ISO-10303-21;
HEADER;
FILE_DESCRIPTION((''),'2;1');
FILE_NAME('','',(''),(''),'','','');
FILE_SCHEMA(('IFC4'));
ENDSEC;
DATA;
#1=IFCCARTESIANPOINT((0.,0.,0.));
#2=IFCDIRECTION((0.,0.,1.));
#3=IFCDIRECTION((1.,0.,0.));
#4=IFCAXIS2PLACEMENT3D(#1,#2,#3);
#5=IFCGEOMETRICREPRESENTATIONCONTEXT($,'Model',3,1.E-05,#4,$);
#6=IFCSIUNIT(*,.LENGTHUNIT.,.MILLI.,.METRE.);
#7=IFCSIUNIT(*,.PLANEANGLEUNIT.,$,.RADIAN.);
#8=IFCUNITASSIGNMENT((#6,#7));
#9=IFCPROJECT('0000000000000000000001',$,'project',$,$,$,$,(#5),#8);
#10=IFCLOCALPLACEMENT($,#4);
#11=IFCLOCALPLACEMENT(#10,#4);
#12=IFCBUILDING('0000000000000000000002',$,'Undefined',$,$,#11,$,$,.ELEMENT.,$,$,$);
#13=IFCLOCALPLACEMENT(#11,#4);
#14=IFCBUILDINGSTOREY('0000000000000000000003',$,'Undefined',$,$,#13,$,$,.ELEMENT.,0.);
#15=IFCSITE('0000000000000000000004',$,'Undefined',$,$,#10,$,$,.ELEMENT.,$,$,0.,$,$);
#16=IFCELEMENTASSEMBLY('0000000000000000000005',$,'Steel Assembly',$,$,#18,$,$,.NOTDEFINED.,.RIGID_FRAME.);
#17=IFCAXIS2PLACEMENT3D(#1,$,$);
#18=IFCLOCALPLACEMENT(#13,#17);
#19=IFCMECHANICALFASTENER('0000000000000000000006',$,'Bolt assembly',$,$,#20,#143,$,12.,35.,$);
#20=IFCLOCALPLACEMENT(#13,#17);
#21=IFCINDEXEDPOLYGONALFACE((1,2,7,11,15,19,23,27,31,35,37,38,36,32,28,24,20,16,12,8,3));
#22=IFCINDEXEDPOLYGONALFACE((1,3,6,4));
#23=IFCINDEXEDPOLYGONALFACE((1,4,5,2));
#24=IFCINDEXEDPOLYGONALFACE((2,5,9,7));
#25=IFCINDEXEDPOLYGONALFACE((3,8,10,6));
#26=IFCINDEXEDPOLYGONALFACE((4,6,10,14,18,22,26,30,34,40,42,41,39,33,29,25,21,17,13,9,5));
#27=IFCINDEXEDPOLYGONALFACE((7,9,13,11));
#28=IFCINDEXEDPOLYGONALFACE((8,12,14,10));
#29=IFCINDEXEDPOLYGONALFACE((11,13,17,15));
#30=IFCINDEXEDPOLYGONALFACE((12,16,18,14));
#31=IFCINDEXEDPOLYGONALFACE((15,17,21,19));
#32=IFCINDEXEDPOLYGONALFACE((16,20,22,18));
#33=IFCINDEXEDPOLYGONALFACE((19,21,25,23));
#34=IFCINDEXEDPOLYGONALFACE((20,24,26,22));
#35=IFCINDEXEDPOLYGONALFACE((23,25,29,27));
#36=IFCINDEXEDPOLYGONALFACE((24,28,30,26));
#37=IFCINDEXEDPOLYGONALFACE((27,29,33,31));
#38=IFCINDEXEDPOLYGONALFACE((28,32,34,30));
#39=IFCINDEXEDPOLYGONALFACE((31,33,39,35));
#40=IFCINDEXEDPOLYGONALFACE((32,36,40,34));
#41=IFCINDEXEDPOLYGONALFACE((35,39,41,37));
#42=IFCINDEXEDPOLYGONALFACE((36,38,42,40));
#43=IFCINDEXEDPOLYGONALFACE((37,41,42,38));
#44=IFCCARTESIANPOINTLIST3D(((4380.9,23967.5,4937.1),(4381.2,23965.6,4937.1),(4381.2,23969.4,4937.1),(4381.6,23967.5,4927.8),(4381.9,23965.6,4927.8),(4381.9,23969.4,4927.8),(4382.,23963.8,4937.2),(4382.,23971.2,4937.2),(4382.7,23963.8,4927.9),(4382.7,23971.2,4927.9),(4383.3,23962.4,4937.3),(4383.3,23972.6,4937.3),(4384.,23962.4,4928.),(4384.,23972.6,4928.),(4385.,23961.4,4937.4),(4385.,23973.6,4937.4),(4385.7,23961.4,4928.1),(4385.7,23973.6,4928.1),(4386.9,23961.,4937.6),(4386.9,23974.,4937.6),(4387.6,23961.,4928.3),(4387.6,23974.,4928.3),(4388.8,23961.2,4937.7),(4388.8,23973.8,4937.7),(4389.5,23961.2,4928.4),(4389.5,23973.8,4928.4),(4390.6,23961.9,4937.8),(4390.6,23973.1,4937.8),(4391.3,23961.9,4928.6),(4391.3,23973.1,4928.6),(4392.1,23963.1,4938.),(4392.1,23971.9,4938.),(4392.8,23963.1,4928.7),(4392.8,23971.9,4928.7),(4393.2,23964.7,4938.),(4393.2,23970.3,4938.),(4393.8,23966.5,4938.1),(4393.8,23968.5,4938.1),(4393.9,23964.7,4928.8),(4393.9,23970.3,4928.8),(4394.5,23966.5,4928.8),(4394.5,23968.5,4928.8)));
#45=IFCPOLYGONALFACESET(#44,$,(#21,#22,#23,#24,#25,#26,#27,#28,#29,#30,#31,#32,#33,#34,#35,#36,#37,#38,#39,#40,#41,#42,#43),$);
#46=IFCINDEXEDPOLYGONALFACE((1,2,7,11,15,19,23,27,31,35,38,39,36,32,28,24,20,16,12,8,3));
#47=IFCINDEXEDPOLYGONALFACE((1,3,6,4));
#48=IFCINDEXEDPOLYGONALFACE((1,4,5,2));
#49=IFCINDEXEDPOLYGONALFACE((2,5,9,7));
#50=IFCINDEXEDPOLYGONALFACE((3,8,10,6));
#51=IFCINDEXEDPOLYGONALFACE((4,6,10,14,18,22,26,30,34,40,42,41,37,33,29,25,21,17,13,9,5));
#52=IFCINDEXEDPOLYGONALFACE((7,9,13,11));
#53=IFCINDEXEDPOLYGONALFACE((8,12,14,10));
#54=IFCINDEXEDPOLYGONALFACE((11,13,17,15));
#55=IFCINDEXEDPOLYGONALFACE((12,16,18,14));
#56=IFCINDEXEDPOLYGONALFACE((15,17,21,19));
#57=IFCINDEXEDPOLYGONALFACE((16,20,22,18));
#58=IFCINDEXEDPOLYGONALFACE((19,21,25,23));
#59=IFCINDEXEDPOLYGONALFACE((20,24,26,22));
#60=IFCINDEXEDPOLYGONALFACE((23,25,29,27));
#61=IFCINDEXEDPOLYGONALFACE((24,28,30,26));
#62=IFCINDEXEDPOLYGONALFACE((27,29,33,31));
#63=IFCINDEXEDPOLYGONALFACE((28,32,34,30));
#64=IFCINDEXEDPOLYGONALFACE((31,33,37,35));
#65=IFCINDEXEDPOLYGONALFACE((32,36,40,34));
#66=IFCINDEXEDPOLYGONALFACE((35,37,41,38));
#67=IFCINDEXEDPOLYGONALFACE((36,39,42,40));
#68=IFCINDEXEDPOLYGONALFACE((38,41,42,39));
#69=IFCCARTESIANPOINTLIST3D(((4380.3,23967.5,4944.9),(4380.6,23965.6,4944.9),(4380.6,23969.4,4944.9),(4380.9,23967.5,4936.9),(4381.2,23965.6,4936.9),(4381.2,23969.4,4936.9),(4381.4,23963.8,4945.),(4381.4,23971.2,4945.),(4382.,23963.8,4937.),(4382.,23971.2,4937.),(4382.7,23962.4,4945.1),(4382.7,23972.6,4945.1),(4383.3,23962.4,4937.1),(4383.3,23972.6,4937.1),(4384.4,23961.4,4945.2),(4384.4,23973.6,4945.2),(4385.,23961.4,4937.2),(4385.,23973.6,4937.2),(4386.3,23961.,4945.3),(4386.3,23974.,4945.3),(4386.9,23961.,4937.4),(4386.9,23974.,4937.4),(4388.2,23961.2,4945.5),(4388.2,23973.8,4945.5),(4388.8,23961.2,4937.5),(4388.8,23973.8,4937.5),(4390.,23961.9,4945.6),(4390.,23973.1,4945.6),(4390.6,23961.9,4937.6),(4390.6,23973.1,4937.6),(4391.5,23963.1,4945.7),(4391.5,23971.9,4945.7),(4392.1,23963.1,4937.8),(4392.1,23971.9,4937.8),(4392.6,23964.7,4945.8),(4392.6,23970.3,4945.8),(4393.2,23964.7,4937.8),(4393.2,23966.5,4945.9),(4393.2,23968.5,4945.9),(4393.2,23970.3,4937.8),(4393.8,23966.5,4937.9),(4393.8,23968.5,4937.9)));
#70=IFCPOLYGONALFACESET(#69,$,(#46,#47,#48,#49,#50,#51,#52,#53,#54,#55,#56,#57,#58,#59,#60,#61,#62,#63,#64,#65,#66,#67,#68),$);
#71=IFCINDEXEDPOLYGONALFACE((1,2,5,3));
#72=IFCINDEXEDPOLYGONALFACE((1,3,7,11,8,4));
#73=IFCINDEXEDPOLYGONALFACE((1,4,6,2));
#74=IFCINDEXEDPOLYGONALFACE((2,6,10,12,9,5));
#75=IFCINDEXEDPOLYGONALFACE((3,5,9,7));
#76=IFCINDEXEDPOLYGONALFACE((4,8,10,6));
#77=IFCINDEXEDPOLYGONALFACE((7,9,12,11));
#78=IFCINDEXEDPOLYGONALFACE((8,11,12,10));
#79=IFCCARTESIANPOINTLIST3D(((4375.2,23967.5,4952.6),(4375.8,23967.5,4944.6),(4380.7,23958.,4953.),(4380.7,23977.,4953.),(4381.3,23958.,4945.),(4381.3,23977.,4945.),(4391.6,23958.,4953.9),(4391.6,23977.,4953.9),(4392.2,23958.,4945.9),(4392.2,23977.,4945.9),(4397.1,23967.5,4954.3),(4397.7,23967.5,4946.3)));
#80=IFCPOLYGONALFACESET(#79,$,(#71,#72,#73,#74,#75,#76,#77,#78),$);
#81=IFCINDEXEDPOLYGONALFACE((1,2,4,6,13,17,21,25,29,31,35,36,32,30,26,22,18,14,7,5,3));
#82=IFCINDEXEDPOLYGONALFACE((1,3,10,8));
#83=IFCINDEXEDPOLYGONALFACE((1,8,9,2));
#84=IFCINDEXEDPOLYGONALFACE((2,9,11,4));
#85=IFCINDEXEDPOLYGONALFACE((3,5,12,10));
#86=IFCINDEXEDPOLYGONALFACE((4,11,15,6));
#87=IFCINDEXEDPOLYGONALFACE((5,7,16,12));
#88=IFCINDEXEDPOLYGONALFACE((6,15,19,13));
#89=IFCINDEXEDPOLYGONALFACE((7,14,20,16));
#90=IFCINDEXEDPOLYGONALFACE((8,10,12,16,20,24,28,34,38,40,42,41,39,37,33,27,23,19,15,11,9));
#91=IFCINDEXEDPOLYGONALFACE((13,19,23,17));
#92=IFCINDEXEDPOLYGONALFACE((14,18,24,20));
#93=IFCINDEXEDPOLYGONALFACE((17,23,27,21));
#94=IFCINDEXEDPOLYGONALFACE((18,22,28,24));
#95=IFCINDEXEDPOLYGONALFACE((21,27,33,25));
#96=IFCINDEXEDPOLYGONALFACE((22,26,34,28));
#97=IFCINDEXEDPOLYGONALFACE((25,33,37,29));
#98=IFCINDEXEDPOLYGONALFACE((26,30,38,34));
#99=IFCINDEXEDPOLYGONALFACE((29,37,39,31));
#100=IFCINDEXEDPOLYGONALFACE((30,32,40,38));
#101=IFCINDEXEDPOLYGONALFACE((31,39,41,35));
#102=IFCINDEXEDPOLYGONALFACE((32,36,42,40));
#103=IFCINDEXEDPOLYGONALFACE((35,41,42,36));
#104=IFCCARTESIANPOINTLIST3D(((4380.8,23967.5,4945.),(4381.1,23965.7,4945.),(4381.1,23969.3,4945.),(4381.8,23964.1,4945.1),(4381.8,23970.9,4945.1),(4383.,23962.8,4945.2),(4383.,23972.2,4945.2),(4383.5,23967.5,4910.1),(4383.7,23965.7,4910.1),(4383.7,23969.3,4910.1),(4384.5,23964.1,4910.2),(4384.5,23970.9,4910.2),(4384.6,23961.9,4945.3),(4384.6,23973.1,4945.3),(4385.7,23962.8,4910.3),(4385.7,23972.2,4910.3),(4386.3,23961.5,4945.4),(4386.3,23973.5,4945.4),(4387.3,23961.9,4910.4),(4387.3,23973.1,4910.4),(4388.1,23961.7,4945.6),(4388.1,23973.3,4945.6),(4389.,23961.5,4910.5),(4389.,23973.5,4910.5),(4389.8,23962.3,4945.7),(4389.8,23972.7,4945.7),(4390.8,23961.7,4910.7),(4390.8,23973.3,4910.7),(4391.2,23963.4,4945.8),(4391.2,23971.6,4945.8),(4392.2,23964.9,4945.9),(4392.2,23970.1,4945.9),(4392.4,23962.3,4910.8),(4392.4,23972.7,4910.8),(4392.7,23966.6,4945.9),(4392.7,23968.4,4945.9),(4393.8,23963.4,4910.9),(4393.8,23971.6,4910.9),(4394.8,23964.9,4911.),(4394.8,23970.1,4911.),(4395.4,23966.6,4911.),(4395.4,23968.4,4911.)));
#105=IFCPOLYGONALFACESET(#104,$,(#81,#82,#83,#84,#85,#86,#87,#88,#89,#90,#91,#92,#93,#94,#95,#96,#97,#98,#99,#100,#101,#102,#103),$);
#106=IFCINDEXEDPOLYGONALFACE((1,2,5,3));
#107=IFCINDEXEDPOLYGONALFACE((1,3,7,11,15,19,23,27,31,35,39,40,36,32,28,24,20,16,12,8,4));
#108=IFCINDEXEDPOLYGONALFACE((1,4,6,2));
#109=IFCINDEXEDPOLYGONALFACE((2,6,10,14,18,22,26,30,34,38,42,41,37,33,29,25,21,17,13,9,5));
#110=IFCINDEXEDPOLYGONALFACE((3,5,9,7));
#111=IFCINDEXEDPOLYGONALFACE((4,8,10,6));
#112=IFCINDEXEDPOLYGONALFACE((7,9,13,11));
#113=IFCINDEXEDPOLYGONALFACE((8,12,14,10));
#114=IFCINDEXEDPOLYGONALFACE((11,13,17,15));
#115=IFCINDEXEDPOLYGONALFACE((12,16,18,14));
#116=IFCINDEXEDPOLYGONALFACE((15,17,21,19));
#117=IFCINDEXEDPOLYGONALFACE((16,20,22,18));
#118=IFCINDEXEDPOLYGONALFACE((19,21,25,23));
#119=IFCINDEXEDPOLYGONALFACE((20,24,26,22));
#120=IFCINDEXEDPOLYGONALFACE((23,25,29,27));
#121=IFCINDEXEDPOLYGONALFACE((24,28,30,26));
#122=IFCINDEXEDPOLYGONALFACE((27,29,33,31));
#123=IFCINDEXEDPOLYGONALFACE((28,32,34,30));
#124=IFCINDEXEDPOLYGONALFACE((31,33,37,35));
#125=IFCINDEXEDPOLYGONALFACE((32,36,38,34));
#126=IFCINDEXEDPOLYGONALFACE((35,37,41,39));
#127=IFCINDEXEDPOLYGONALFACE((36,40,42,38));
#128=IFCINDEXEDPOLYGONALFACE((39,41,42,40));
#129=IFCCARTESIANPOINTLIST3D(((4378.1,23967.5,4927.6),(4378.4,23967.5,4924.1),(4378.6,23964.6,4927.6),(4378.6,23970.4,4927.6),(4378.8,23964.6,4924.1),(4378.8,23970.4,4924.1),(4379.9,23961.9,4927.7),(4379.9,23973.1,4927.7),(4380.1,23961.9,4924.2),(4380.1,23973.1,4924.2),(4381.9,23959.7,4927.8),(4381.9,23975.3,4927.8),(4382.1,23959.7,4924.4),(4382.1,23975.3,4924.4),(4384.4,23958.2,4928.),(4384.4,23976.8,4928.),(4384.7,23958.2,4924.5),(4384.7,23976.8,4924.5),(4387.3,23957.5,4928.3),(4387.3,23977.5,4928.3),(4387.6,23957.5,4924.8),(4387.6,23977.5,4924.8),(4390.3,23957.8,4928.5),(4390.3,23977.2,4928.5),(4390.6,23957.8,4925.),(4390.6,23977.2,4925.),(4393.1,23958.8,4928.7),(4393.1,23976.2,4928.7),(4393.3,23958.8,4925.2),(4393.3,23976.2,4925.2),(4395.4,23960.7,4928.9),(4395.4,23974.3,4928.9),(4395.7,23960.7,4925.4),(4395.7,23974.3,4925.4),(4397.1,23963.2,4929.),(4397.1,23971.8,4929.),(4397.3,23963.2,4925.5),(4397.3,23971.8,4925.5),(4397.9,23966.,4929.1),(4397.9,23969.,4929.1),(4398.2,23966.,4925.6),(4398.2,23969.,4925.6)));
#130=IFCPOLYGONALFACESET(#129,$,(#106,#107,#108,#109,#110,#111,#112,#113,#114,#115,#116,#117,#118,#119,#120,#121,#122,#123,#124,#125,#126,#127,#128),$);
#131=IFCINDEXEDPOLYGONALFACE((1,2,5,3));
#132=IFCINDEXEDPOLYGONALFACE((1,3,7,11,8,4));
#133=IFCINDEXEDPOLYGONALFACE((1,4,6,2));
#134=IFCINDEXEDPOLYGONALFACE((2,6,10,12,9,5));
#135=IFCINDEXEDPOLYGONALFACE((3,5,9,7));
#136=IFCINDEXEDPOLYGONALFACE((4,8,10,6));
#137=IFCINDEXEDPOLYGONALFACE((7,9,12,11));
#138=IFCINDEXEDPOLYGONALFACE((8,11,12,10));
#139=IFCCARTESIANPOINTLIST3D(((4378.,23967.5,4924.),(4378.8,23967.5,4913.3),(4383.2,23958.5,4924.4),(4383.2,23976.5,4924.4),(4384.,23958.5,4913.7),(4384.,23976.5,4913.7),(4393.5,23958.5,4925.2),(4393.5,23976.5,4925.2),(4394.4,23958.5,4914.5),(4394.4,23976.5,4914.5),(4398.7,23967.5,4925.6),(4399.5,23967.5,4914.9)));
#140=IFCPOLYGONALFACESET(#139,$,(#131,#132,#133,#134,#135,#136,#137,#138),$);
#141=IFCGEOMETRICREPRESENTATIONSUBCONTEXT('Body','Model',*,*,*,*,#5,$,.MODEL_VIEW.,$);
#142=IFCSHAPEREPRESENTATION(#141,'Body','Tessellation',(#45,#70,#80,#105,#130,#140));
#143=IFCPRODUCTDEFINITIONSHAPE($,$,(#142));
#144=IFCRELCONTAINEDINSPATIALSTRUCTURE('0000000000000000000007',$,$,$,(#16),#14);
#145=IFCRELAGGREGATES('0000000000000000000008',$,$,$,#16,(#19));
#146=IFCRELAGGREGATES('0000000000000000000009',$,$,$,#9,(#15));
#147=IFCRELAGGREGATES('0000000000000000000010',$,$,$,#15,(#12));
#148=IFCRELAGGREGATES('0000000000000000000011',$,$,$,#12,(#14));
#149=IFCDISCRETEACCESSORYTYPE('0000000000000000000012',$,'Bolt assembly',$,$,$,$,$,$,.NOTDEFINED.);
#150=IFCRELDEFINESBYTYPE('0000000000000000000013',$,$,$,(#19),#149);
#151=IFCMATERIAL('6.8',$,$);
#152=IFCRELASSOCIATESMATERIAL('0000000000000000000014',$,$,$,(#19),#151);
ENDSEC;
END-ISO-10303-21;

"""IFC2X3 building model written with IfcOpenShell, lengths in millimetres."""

from ifc_helpers import new_model, si_unit, frame, origin_with_axes, origin_2d_with_axis, place, context, subcontext, project, spatial, polyline, circle, outline, extrude, source, transform, mapped, material, type_object, element, aggregate, save


model = new_model("IFC2X3")

# Units and contexts
model_context = context("Model", 3, precision=1e-05, world=origin_with_axes())
body_context = subcontext(model_context, "Body", "Model", "MODEL_VIEW")
ifc_project = project(units=[si_unit("LENGTHUNIT", "METRE", prefix="MILLI"), si_unit("PLANEANGLEUNIT", "RADIAN")], contexts=[model_context])

# Site, building, storey
site_placement = place(None, origin_with_axes())
site = spatial("IfcSite", under=ifc_project, at=site_placement, Name="Undefined", CompositionType="ELEMENT", RefElevation=0.0)
building_placement = place(site_placement, origin_with_axes())
building = spatial("IfcBuilding", under=site, at=building_placement, Name="Undefined", CompositionType="ELEMENT")
storey_placement = place(building_placement, origin_with_axes())
storey = spatial("IfcBuildingStorey", under=building, at=storey_placement, Name="Undefined", CompositionType="ELEMENT", Elevation=0.0)

# Shared definitions
ifc_material_1 = material(Name="6.8")
discrete_accessory_type_1 = type_object("IfcDiscreteAccessoryType", Name="Bolt assembly")

# Element assembly, mechanical fastener
assembly_1_placement = place(storey_placement, origin_with_axes())
assembly_1 = element("IfcElementAssembly", 1, at=assembly_1_placement, inside=storey, Name="Steel Assembly", AssemblyPlace="NOTDEFINED", PredefinedType="RIGID_FRAME")
shared_shape_1 = source(origin_with_axes(), body_context, "Body", "SweptSolid", [
    extrude(circle(Radius=6.5, at=origin_2d_with_axis()), frame((0.0, -0.1, 0.0), z_axis=(0.0, 1.0, 0.0), x_axis=(1.0, 0.0, 0.0)), (0.0, 0.0, 1.0), 9.3),
    extrude(circle(Radius=6.5, at=origin_2d_with_axis()), frame((0.0, -7.9, 0.0), z_axis=(0.0, 1.0, 0.0), x_axis=(1.0, 0.0, 0.0)), (0.0, 0.0, 1.0), 8.0),
    extrude(outline(polyline([(11.0, 0.0), (5.5, 9.5), (-5.5, 9.5), (-11.0, 0.0), (-5.5, -9.5), (5.5, -9.5), (11.0, 0.0)])), frame((0.0, -16.0, 0.0), z_axis=(0.0, 1.0, 0.0), x_axis=(1.0, 0.0, 0.0)), (0.0, 0.0, 1.0), 8.0),
    extrude(circle(Radius=6.0, at=origin_2d_with_axis()), frame((0.0, -8.0, 0.0), z_axis=(0.0, 1.0, 0.0), x_axis=(1.0, 0.0, 0.0)), (0.0, 0.0, 1.0), 35.0),
    extrude(circle(Radius=10.0, at=origin_2d_with_axis()), frame((0.0, 9.2, 0.0), z_axis=(0.0, 1.0, 0.0), x_axis=(1.0, 0.0, 0.0)), (0.0, 0.0, 1.0), 3.5),
    extrude(outline(polyline([(10.4, 0.0), (5.2, 9.0), (-5.2, 9.0), (-10.4, 0.0), (-5.2, -9.0), (5.2, -9.0), (10.4, 0.0)])), frame((0.0, 12.7, 0.0), z_axis=(0.0, 1.0, 0.0), x_axis=(1.0, 0.0, 0.0)), (0.0, 0.0, 1.0), 10.8),
])
mechanical_fastener_1_placement = place(assembly_1_placement, frame((4387.4, 23967.5, 4937.5), z_axis=(0.0, -1.0, 0.0), x_axis=(-0.997054, 0.0, -0.076696)))
mechanical_fastener_1 = element("IfcMechanicalFastener", 2, at=mechanical_fastener_1_placement, type_object=discrete_accessory_type_1, material=ifc_material_1, Name="Bolt assembly", NominalDiameter=12.0, NominalLength=35.0, context=body_context, shape_type="MappedRepresentation", body=[
    mapped(shared_shape_1, transform((0.0, 0.0, 0.0))),
])
aggregate(assembly_1, [mechanical_fastener_1])

save(model, "model.ifc")
